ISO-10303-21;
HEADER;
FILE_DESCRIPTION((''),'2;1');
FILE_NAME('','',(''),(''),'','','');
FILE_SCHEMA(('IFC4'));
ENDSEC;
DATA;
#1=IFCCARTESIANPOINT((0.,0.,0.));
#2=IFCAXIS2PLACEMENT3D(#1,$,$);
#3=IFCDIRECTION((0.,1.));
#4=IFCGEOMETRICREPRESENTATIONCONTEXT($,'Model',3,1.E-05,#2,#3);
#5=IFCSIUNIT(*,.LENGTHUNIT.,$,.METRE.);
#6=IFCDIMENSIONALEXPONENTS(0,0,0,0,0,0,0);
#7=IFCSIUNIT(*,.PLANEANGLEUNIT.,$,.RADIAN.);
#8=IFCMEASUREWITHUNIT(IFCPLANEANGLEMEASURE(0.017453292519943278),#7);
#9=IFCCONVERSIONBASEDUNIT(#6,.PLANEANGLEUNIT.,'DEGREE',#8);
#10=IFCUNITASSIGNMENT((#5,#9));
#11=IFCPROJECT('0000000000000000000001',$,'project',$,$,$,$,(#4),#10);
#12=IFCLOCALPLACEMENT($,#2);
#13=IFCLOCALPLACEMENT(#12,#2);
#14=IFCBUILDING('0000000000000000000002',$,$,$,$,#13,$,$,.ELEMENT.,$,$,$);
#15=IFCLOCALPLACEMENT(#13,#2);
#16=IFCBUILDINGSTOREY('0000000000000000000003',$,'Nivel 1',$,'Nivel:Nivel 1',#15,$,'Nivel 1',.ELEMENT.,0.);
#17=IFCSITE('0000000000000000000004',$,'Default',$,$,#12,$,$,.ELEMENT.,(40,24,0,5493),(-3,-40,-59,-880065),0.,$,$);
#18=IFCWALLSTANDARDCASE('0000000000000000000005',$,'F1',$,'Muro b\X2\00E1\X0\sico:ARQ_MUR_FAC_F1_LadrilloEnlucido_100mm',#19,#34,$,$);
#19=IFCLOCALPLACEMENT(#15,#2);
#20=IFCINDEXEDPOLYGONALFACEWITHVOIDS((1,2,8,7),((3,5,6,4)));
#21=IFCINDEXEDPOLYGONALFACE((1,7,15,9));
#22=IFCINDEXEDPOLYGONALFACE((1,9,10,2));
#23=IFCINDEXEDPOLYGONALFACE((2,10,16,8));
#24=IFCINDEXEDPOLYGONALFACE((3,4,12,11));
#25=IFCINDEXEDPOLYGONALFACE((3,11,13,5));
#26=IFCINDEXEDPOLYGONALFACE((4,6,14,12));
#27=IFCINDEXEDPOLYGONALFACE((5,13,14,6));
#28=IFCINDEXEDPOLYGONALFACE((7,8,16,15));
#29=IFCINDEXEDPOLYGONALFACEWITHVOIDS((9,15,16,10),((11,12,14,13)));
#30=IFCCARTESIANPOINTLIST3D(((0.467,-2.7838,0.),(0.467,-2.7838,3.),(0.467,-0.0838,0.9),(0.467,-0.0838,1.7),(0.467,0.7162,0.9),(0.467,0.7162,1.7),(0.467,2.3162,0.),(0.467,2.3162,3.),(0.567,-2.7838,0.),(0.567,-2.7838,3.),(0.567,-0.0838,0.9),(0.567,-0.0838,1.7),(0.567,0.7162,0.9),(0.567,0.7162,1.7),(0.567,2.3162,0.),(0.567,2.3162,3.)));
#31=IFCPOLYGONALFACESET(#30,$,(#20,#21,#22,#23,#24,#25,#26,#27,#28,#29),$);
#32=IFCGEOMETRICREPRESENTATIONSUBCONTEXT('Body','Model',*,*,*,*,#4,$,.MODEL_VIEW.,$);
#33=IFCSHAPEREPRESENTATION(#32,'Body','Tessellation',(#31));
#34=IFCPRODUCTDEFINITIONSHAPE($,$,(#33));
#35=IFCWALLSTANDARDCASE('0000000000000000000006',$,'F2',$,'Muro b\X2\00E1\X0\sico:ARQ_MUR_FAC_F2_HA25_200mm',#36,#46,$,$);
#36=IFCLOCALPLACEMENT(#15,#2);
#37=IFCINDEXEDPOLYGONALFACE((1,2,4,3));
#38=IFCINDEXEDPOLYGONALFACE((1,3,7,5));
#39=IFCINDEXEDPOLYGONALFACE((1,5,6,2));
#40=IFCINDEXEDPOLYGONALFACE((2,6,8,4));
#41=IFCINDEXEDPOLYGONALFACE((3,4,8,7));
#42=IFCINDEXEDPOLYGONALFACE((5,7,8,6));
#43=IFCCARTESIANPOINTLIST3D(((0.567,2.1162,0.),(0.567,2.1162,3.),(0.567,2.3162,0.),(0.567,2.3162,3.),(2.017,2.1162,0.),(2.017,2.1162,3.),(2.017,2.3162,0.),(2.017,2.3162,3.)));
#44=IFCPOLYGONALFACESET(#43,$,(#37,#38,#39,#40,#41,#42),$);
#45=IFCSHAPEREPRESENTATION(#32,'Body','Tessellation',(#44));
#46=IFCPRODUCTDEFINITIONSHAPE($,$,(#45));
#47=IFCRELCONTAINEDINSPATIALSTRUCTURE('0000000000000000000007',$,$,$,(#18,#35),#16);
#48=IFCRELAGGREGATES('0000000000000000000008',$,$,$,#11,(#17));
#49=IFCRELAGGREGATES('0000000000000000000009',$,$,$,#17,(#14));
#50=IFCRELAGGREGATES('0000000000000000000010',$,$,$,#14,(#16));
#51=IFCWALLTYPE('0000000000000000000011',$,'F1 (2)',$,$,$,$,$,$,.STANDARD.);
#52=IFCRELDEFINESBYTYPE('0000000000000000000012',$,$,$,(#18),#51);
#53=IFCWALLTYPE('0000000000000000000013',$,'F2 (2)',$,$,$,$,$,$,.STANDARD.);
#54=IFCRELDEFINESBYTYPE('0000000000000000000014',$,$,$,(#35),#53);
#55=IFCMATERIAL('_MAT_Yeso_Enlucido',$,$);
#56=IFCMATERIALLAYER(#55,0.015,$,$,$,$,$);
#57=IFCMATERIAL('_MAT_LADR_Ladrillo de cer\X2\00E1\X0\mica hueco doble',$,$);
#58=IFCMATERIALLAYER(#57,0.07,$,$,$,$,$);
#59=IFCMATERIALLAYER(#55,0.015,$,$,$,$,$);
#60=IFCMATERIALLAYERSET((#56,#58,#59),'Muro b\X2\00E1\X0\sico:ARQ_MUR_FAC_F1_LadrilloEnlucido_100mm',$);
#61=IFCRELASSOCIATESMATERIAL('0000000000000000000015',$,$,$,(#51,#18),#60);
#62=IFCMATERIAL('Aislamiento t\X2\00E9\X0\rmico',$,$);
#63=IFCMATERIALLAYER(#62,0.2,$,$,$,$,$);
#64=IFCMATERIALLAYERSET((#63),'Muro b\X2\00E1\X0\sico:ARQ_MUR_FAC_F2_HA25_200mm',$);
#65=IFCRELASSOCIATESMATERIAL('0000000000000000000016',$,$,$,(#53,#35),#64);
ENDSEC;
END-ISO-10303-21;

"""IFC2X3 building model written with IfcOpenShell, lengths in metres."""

from ifc_helpers import new_model, entity, si_unit, converted_unit, direction, frame, frame_2d, origin, place, context, subcontext, project, spatial, rectangle, extrude, material, layer, layer_set, layer_usage, type_object, element, save


model = new_model("IFC2X3")

# Units and contexts
model_context = context("Model", 3, precision=1e-05, world=origin(), true_north=direction((0.0, 1.0)))
body_context = subcontext(model_context, "Body", "Model", "MODEL_VIEW")
ifc_project = project(units=[si_unit("LENGTHUNIT", "METRE"), converted_unit("PLANEANGLEUNIT", "DEGREE", entity("IfcPlaneAngleMeasure", 0.017453292519943278), si_unit("PLANEANGLEUNIT", "RADIAN"), dimensions=[0, 0, 0, 0, 0, 0, 0])], contexts=[model_context])

# Site, building, storey
site_placement = place(None, origin())
site = spatial("IfcSite", under=ifc_project, at=site_placement, Name="Default", CompositionType="ELEMENT", RefLatitude=(40, 24, 0, 5493), RefLongitude=(-3, -40, -59, -880065), RefElevation=0.0)
building_placement = place(site_placement, origin())
building = spatial("IfcBuilding", under=site, at=building_placement, CompositionType="ELEMENT")
storey_placement = place(building_placement, origin())
storey = spatial("IfcBuildingStorey", under=building, at=storey_placement, Name="Nivel 1", ObjectType="Nivel:Nivel 1", LongName="Nivel 1", CompositionType="ELEMENT", Elevation=0.0)

# Wall, opening
ifc_material_1 = material(Name="_MAT_Yeso_Enlucido")
ifc_layer_1 = layer(ifc_material_1, 0.015)
ifc_material_2 = material(Name="_MAT_LADR_Ladrillo de cerámica hueco doble")
ifc_layer_2 = layer(ifc_material_2, 0.07)
ifc_layer_3 = layer(ifc_material_1, 0.015)
ifc_layer_set_1 = layer_set([ifc_layer_1, ifc_layer_2, ifc_layer_3], Name="Muro básico:ARQ_MUR_FAC_F1_LadrilloEnlucido_100mm")
ifc_layer_usage_1 = layer_usage(ifc_layer_set_1, "AXIS2", "NEGATIVE", 0.05)
wall_type_1 = type_object("IfcWallType", Name="F1 (2)", PredefinedType="STANDARD", material=ifc_layer_set_1)
wall_1_placement = place(storey_placement, frame((0.517, -2.7838, 0.0), z_axis=(0.0, 0.0, 1.0), x_axis=(0.0, 1.0, 0.0)))
wall_1 = element("IfcWallStandardCase", 1, at=wall_1_placement, inside=storey, type_object=wall_type_1, material=ifc_layer_usage_1, Name="F1", ObjectType="Muro básico:ARQ_MUR_FAC_F1_LadrilloEnlucido_100mm", context=body_context, shape_type="SweptSolid", body=[
    extrude(rectangle(XDim=5.1, YDim=0.1, at=frame_2d((2.55, 0.0), x_axis=(-1.0, 0.0))), origin(), (0.0, 0.0, 1.0), 3.0),
])
opening_placement = place(wall_1_placement, frame((2.7, -0.05, 0.9)))
element("IfcOpeningElement", 2, at=opening_placement, cuts=wall_1, ObjectType="Opening", context=body_context, shape_type="SweptSolid", body=[
    extrude(rectangle(XDim=0.8, YDim=0.8, at=frame_2d((0.4, 0.4), x_axis=(1.0, 0.0))), frame((0.0, 0.0, 0.0), z_axis=(0.0, 1.0, 0.0), x_axis=(0.0, 0.0, 1.0)), (0.0, 0.0, 1.0), 0.1),
])

# Wall
ifc_material_3 = material(Name="Aislamiento térmico")
ifc_layer_4 = layer(ifc_material_3, 0.2)
ifc_layer_set_2 = layer_set([ifc_layer_4], Name="Muro básico:ARQ_MUR_FAC_F2_HA25_200mm")
ifc_layer_usage_2 = layer_usage(ifc_layer_set_2, "AXIS2", "NEGATIVE", 0.1)
wall_type_2 = type_object("IfcWallType", Name="F2 (2)", PredefinedType="STANDARD", material=ifc_layer_set_2)
wall_2_placement = place(storey_placement, frame((0.567, 2.2162, 0.0)))
element("IfcWallStandardCase", 3, at=wall_2_placement, inside=storey, type_object=wall_type_2, material=ifc_layer_usage_2, Name="F2", ObjectType="Muro básico:ARQ_MUR_FAC_F2_HA25_200mm", context=body_context, shape_type="SweptSolid", body=[
    extrude(rectangle(XDim=1.45, YDim=0.2, at=frame_2d((0.725, 0.0), x_axis=(-1.0, 0.0))), origin(), (0.0, 0.0, 1.0), 3.0),
])

save(model, "model.ifc")
